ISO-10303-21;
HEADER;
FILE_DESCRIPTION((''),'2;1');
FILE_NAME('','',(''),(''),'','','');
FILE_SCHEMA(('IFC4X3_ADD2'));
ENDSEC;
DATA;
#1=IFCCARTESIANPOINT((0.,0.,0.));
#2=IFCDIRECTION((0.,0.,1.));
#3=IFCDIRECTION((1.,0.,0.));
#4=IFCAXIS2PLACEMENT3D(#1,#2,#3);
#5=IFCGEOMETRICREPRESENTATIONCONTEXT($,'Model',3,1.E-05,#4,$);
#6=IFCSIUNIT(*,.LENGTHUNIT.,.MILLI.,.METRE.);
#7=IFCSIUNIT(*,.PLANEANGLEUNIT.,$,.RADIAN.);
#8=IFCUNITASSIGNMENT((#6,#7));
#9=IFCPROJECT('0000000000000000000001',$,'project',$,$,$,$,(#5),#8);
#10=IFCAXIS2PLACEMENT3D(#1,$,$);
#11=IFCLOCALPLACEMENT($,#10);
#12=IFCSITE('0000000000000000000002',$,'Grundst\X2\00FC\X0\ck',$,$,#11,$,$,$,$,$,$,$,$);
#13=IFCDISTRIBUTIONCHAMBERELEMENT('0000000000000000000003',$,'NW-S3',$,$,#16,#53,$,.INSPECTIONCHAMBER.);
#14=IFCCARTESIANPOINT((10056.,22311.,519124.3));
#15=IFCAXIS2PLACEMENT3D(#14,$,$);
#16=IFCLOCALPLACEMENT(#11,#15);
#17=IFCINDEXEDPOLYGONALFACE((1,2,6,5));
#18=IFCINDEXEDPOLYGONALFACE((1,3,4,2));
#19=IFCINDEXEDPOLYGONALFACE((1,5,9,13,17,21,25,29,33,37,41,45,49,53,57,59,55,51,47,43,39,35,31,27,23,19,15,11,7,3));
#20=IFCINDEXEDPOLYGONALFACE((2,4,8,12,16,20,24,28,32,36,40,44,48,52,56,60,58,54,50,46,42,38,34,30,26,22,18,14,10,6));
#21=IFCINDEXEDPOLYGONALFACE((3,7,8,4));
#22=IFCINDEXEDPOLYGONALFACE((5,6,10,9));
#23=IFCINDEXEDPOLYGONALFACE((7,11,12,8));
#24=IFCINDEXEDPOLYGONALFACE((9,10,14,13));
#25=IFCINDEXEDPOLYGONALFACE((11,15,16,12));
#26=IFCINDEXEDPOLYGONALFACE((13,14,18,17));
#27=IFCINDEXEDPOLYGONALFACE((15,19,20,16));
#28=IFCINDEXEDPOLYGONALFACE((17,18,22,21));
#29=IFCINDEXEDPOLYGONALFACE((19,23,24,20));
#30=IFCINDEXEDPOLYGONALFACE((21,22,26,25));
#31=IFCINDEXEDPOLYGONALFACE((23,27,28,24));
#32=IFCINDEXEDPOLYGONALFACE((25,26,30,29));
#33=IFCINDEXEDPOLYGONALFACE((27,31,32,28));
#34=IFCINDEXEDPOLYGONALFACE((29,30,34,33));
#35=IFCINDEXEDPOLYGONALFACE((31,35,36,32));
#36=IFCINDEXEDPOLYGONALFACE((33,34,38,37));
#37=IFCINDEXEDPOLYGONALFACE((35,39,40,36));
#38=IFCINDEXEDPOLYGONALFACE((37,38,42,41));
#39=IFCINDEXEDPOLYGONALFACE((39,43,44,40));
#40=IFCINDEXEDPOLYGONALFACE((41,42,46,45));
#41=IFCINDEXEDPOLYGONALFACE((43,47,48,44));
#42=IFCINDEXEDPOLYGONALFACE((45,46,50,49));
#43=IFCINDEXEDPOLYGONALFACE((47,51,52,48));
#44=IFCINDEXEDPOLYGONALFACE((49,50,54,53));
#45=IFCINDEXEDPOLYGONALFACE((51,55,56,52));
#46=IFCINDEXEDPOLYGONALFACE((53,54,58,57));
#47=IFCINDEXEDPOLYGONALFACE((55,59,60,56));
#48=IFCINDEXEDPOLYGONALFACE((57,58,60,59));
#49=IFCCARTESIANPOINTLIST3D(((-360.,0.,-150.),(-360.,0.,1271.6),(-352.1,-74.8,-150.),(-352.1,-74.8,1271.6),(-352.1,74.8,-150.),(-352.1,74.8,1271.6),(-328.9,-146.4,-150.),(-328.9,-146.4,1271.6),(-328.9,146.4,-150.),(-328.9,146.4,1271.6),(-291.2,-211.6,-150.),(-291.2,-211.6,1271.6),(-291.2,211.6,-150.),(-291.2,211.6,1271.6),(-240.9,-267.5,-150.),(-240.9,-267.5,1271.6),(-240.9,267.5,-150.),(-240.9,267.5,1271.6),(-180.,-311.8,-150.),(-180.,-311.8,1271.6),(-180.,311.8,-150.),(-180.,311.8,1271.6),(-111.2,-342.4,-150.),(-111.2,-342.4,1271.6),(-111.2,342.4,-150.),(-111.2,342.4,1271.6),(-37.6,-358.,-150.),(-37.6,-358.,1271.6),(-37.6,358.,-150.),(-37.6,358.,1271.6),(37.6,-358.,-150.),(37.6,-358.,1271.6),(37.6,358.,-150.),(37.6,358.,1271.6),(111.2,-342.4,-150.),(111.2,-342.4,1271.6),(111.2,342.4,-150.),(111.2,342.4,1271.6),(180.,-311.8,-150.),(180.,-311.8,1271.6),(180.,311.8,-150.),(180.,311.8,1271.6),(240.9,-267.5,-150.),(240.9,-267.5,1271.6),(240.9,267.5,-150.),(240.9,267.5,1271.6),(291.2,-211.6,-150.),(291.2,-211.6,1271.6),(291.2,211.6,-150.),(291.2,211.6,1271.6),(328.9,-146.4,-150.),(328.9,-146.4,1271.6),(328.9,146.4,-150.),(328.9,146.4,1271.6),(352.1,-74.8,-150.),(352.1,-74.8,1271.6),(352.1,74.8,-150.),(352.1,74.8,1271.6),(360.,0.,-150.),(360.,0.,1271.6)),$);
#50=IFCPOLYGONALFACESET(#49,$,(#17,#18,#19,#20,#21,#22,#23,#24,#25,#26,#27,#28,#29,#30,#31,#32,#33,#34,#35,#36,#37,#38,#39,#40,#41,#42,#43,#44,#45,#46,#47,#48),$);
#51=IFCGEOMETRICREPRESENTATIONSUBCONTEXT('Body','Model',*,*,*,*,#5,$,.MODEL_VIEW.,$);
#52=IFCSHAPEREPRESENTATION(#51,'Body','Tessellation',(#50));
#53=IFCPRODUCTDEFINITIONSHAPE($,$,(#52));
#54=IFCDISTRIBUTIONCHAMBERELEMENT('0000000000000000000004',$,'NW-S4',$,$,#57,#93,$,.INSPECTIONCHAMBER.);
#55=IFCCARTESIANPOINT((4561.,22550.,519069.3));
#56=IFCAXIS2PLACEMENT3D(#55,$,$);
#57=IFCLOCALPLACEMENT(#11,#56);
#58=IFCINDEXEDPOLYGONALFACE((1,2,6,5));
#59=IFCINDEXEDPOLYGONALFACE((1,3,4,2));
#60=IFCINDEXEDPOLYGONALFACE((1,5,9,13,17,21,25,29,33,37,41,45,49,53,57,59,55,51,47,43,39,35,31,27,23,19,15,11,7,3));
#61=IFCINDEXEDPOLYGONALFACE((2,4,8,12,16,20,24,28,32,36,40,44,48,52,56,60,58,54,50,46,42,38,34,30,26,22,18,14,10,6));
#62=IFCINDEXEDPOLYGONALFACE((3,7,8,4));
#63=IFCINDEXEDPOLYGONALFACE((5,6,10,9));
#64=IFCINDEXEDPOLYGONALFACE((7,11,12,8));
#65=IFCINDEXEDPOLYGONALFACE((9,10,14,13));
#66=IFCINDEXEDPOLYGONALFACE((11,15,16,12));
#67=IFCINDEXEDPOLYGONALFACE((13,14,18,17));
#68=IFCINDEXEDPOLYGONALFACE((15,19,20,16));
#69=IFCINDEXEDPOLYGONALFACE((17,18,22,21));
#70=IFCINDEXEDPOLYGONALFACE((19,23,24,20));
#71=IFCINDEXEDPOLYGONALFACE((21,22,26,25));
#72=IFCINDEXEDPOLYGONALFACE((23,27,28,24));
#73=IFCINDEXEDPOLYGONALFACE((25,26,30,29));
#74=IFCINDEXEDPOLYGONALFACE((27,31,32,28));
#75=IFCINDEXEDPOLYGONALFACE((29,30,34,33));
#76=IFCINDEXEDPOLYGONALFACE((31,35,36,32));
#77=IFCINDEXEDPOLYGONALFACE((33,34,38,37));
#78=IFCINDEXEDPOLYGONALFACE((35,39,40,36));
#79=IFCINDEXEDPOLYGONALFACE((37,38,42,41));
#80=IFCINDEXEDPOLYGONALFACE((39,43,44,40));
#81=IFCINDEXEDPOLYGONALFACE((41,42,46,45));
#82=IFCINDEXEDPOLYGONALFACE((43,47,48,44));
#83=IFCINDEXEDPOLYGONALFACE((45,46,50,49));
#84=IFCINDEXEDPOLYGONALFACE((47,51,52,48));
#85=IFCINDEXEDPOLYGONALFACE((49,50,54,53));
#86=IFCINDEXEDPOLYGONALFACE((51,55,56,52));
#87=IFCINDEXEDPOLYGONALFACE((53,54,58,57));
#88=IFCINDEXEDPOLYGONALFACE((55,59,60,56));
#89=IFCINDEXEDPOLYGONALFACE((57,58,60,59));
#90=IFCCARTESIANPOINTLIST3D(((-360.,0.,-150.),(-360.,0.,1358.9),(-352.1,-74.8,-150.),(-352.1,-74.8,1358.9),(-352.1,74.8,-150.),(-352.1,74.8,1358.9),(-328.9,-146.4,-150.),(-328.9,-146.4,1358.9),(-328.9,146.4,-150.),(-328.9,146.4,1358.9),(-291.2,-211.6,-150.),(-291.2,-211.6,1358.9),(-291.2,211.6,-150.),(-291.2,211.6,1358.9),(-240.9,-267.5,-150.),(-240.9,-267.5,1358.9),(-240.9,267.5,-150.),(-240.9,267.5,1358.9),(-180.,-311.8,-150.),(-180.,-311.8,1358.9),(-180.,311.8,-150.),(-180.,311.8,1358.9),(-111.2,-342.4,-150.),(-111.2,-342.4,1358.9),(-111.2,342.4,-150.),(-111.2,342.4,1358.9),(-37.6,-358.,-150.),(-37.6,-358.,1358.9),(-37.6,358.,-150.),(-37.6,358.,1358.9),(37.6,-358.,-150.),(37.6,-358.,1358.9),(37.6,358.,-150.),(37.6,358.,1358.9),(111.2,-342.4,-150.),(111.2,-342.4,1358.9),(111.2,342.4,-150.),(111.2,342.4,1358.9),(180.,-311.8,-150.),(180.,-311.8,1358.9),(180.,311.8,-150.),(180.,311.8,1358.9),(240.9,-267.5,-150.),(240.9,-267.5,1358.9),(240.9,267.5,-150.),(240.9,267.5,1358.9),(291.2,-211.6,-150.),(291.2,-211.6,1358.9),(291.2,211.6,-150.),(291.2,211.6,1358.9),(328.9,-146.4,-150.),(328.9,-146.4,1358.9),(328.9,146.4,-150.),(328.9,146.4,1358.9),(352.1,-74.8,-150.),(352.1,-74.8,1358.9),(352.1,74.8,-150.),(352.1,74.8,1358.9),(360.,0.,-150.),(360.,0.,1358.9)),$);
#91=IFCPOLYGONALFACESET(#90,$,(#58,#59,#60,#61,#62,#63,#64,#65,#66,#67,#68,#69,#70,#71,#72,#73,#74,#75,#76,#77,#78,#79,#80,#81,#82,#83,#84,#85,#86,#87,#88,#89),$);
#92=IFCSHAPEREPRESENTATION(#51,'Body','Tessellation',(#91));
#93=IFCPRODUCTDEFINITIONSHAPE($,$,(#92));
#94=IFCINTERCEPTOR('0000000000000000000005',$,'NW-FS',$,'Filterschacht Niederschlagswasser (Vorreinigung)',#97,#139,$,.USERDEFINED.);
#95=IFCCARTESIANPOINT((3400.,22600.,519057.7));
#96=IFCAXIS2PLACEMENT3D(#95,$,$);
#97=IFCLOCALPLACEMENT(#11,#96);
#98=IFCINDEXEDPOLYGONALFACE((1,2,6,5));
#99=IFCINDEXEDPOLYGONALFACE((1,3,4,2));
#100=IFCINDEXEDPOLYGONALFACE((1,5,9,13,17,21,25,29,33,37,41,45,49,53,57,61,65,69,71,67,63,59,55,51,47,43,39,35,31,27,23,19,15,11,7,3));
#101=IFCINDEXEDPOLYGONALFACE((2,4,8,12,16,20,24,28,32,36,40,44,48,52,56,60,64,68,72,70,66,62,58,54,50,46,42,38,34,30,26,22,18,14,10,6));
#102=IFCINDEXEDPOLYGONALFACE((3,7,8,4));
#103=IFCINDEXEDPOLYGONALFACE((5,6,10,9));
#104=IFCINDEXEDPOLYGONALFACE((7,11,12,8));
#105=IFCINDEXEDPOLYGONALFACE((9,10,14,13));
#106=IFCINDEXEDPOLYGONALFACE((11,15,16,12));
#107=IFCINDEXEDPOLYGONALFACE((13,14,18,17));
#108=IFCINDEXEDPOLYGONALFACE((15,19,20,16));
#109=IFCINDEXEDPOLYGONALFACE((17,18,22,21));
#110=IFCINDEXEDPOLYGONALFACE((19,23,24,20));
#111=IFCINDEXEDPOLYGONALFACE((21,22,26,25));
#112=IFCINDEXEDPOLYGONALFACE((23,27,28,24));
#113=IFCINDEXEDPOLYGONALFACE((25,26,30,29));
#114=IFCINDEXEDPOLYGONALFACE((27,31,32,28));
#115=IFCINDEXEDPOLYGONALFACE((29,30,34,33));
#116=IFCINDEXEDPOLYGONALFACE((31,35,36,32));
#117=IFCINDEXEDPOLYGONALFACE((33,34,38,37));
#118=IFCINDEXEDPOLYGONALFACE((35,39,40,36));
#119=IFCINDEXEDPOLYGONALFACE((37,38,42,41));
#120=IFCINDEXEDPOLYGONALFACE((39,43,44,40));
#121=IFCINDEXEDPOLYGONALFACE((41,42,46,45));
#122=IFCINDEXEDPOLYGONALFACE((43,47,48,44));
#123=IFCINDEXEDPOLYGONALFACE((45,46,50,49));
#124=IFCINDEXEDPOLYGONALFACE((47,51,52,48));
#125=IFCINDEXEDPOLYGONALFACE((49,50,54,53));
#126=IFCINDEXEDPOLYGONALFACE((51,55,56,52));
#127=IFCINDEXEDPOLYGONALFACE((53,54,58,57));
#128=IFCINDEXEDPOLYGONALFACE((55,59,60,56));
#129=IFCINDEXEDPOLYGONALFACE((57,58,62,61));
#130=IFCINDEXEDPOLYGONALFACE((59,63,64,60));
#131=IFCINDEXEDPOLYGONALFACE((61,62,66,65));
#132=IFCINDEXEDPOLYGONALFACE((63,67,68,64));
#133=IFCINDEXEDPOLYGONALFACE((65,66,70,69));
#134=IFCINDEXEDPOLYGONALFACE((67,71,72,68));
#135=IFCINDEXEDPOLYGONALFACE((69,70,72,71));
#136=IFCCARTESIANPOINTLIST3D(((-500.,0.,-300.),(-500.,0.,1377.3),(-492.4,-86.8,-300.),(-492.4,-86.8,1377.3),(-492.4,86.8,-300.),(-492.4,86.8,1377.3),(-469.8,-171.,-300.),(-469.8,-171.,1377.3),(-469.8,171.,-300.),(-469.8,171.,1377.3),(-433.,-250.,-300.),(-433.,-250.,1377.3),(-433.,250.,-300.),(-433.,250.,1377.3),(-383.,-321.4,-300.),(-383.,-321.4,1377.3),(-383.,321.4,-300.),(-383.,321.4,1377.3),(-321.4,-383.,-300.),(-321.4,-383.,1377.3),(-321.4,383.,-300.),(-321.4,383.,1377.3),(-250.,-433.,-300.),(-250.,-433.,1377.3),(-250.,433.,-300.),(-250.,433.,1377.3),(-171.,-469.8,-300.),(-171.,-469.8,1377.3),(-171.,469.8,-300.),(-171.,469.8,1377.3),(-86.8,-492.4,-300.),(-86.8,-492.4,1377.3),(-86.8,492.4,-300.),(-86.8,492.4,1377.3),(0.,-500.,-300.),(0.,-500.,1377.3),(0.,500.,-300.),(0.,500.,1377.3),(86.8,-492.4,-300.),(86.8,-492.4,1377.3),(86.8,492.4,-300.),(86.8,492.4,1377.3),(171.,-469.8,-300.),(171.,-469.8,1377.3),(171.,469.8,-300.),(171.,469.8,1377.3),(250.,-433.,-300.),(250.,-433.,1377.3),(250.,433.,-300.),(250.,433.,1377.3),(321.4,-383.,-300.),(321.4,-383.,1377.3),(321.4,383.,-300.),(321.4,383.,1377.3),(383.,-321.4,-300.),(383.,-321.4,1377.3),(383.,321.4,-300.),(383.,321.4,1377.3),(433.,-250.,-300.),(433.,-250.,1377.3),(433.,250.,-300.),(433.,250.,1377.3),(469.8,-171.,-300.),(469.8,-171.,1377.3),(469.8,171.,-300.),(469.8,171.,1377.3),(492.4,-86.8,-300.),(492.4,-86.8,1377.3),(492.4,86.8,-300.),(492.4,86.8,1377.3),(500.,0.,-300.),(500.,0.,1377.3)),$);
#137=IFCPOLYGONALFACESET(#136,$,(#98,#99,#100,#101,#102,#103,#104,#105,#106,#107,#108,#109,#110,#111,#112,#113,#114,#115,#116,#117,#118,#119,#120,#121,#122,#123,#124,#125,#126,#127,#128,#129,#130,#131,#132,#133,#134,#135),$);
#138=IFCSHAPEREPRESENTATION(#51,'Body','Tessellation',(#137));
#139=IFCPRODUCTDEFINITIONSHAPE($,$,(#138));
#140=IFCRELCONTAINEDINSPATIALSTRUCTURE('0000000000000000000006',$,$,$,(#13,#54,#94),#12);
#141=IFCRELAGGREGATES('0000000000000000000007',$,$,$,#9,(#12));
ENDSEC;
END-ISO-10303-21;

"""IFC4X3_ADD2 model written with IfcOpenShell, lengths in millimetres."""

from ifc_helpers import new_model, si_unit, frame, origin, origin_with_axes, place, context, subcontext, project, spatial, circle, extrude, element, save


model = new_model("IFC4X3_ADD2")

# Units and contexts
model_context = context("Model", 3, precision=1e-05, world=origin_with_axes())
body_context = subcontext(model_context, "Body", "Model", "MODEL_VIEW")
ifc_project = project(units=[si_unit("LENGTHUNIT", "METRE", prefix="MILLI"), si_unit("PLANEANGLEUNIT", "RADIAN")], contexts=[model_context])

# Site
site_placement = place(None, origin())
site = spatial("IfcSite", under=ifc_project, at=site_placement, Name="Grundstück")

# Distribution chamber elements
distribution_chamber_element_1_placement = place(site_placement, frame((10056.0, 22311.0, 519124.3)))
element("IfcDistributionChamberElement", 1, at=distribution_chamber_element_1_placement, inside=site, Name="NW-S3", PredefinedType="INSPECTIONCHAMBER", context=body_context, shape_type="SweptSolid", body=[
    extrude(circle(Radius=360.0), frame((0.0, 0.0, -150.0)), (0.0, 0.0, 1.0), 1421.6),
])
distribution_chamber_element_2_placement = place(site_placement, frame((4561.0, 22550.0, 519069.3)))
element("IfcDistributionChamberElement", 2, at=distribution_chamber_element_2_placement, inside=site, Name="NW-S4", PredefinedType="INSPECTIONCHAMBER", context=body_context, shape_type="SweptSolid", body=[
    extrude(circle(Radius=360.0), frame((0.0, 0.0, -150.0)), (0.0, 0.0, 1.0), 1508.9),
])

# Interceptor
interceptor_placement = place(site_placement, frame((3400.0, 22600.0, 519057.7)))
element("IfcInterceptor", 3, at=interceptor_placement, inside=site, Name="NW-FS", ObjectType="Filterschacht Niederschlagswasser (Vorreinigung)", PredefinedType="USERDEFINED", context=body_context, shape_type="SweptSolid", body=[
    extrude(circle(Radius=500.0), frame((0.0, 0.0, -300.0)), (0.0, 0.0, 1.0), 1677.3),
])

save(model, "model.ifc")
